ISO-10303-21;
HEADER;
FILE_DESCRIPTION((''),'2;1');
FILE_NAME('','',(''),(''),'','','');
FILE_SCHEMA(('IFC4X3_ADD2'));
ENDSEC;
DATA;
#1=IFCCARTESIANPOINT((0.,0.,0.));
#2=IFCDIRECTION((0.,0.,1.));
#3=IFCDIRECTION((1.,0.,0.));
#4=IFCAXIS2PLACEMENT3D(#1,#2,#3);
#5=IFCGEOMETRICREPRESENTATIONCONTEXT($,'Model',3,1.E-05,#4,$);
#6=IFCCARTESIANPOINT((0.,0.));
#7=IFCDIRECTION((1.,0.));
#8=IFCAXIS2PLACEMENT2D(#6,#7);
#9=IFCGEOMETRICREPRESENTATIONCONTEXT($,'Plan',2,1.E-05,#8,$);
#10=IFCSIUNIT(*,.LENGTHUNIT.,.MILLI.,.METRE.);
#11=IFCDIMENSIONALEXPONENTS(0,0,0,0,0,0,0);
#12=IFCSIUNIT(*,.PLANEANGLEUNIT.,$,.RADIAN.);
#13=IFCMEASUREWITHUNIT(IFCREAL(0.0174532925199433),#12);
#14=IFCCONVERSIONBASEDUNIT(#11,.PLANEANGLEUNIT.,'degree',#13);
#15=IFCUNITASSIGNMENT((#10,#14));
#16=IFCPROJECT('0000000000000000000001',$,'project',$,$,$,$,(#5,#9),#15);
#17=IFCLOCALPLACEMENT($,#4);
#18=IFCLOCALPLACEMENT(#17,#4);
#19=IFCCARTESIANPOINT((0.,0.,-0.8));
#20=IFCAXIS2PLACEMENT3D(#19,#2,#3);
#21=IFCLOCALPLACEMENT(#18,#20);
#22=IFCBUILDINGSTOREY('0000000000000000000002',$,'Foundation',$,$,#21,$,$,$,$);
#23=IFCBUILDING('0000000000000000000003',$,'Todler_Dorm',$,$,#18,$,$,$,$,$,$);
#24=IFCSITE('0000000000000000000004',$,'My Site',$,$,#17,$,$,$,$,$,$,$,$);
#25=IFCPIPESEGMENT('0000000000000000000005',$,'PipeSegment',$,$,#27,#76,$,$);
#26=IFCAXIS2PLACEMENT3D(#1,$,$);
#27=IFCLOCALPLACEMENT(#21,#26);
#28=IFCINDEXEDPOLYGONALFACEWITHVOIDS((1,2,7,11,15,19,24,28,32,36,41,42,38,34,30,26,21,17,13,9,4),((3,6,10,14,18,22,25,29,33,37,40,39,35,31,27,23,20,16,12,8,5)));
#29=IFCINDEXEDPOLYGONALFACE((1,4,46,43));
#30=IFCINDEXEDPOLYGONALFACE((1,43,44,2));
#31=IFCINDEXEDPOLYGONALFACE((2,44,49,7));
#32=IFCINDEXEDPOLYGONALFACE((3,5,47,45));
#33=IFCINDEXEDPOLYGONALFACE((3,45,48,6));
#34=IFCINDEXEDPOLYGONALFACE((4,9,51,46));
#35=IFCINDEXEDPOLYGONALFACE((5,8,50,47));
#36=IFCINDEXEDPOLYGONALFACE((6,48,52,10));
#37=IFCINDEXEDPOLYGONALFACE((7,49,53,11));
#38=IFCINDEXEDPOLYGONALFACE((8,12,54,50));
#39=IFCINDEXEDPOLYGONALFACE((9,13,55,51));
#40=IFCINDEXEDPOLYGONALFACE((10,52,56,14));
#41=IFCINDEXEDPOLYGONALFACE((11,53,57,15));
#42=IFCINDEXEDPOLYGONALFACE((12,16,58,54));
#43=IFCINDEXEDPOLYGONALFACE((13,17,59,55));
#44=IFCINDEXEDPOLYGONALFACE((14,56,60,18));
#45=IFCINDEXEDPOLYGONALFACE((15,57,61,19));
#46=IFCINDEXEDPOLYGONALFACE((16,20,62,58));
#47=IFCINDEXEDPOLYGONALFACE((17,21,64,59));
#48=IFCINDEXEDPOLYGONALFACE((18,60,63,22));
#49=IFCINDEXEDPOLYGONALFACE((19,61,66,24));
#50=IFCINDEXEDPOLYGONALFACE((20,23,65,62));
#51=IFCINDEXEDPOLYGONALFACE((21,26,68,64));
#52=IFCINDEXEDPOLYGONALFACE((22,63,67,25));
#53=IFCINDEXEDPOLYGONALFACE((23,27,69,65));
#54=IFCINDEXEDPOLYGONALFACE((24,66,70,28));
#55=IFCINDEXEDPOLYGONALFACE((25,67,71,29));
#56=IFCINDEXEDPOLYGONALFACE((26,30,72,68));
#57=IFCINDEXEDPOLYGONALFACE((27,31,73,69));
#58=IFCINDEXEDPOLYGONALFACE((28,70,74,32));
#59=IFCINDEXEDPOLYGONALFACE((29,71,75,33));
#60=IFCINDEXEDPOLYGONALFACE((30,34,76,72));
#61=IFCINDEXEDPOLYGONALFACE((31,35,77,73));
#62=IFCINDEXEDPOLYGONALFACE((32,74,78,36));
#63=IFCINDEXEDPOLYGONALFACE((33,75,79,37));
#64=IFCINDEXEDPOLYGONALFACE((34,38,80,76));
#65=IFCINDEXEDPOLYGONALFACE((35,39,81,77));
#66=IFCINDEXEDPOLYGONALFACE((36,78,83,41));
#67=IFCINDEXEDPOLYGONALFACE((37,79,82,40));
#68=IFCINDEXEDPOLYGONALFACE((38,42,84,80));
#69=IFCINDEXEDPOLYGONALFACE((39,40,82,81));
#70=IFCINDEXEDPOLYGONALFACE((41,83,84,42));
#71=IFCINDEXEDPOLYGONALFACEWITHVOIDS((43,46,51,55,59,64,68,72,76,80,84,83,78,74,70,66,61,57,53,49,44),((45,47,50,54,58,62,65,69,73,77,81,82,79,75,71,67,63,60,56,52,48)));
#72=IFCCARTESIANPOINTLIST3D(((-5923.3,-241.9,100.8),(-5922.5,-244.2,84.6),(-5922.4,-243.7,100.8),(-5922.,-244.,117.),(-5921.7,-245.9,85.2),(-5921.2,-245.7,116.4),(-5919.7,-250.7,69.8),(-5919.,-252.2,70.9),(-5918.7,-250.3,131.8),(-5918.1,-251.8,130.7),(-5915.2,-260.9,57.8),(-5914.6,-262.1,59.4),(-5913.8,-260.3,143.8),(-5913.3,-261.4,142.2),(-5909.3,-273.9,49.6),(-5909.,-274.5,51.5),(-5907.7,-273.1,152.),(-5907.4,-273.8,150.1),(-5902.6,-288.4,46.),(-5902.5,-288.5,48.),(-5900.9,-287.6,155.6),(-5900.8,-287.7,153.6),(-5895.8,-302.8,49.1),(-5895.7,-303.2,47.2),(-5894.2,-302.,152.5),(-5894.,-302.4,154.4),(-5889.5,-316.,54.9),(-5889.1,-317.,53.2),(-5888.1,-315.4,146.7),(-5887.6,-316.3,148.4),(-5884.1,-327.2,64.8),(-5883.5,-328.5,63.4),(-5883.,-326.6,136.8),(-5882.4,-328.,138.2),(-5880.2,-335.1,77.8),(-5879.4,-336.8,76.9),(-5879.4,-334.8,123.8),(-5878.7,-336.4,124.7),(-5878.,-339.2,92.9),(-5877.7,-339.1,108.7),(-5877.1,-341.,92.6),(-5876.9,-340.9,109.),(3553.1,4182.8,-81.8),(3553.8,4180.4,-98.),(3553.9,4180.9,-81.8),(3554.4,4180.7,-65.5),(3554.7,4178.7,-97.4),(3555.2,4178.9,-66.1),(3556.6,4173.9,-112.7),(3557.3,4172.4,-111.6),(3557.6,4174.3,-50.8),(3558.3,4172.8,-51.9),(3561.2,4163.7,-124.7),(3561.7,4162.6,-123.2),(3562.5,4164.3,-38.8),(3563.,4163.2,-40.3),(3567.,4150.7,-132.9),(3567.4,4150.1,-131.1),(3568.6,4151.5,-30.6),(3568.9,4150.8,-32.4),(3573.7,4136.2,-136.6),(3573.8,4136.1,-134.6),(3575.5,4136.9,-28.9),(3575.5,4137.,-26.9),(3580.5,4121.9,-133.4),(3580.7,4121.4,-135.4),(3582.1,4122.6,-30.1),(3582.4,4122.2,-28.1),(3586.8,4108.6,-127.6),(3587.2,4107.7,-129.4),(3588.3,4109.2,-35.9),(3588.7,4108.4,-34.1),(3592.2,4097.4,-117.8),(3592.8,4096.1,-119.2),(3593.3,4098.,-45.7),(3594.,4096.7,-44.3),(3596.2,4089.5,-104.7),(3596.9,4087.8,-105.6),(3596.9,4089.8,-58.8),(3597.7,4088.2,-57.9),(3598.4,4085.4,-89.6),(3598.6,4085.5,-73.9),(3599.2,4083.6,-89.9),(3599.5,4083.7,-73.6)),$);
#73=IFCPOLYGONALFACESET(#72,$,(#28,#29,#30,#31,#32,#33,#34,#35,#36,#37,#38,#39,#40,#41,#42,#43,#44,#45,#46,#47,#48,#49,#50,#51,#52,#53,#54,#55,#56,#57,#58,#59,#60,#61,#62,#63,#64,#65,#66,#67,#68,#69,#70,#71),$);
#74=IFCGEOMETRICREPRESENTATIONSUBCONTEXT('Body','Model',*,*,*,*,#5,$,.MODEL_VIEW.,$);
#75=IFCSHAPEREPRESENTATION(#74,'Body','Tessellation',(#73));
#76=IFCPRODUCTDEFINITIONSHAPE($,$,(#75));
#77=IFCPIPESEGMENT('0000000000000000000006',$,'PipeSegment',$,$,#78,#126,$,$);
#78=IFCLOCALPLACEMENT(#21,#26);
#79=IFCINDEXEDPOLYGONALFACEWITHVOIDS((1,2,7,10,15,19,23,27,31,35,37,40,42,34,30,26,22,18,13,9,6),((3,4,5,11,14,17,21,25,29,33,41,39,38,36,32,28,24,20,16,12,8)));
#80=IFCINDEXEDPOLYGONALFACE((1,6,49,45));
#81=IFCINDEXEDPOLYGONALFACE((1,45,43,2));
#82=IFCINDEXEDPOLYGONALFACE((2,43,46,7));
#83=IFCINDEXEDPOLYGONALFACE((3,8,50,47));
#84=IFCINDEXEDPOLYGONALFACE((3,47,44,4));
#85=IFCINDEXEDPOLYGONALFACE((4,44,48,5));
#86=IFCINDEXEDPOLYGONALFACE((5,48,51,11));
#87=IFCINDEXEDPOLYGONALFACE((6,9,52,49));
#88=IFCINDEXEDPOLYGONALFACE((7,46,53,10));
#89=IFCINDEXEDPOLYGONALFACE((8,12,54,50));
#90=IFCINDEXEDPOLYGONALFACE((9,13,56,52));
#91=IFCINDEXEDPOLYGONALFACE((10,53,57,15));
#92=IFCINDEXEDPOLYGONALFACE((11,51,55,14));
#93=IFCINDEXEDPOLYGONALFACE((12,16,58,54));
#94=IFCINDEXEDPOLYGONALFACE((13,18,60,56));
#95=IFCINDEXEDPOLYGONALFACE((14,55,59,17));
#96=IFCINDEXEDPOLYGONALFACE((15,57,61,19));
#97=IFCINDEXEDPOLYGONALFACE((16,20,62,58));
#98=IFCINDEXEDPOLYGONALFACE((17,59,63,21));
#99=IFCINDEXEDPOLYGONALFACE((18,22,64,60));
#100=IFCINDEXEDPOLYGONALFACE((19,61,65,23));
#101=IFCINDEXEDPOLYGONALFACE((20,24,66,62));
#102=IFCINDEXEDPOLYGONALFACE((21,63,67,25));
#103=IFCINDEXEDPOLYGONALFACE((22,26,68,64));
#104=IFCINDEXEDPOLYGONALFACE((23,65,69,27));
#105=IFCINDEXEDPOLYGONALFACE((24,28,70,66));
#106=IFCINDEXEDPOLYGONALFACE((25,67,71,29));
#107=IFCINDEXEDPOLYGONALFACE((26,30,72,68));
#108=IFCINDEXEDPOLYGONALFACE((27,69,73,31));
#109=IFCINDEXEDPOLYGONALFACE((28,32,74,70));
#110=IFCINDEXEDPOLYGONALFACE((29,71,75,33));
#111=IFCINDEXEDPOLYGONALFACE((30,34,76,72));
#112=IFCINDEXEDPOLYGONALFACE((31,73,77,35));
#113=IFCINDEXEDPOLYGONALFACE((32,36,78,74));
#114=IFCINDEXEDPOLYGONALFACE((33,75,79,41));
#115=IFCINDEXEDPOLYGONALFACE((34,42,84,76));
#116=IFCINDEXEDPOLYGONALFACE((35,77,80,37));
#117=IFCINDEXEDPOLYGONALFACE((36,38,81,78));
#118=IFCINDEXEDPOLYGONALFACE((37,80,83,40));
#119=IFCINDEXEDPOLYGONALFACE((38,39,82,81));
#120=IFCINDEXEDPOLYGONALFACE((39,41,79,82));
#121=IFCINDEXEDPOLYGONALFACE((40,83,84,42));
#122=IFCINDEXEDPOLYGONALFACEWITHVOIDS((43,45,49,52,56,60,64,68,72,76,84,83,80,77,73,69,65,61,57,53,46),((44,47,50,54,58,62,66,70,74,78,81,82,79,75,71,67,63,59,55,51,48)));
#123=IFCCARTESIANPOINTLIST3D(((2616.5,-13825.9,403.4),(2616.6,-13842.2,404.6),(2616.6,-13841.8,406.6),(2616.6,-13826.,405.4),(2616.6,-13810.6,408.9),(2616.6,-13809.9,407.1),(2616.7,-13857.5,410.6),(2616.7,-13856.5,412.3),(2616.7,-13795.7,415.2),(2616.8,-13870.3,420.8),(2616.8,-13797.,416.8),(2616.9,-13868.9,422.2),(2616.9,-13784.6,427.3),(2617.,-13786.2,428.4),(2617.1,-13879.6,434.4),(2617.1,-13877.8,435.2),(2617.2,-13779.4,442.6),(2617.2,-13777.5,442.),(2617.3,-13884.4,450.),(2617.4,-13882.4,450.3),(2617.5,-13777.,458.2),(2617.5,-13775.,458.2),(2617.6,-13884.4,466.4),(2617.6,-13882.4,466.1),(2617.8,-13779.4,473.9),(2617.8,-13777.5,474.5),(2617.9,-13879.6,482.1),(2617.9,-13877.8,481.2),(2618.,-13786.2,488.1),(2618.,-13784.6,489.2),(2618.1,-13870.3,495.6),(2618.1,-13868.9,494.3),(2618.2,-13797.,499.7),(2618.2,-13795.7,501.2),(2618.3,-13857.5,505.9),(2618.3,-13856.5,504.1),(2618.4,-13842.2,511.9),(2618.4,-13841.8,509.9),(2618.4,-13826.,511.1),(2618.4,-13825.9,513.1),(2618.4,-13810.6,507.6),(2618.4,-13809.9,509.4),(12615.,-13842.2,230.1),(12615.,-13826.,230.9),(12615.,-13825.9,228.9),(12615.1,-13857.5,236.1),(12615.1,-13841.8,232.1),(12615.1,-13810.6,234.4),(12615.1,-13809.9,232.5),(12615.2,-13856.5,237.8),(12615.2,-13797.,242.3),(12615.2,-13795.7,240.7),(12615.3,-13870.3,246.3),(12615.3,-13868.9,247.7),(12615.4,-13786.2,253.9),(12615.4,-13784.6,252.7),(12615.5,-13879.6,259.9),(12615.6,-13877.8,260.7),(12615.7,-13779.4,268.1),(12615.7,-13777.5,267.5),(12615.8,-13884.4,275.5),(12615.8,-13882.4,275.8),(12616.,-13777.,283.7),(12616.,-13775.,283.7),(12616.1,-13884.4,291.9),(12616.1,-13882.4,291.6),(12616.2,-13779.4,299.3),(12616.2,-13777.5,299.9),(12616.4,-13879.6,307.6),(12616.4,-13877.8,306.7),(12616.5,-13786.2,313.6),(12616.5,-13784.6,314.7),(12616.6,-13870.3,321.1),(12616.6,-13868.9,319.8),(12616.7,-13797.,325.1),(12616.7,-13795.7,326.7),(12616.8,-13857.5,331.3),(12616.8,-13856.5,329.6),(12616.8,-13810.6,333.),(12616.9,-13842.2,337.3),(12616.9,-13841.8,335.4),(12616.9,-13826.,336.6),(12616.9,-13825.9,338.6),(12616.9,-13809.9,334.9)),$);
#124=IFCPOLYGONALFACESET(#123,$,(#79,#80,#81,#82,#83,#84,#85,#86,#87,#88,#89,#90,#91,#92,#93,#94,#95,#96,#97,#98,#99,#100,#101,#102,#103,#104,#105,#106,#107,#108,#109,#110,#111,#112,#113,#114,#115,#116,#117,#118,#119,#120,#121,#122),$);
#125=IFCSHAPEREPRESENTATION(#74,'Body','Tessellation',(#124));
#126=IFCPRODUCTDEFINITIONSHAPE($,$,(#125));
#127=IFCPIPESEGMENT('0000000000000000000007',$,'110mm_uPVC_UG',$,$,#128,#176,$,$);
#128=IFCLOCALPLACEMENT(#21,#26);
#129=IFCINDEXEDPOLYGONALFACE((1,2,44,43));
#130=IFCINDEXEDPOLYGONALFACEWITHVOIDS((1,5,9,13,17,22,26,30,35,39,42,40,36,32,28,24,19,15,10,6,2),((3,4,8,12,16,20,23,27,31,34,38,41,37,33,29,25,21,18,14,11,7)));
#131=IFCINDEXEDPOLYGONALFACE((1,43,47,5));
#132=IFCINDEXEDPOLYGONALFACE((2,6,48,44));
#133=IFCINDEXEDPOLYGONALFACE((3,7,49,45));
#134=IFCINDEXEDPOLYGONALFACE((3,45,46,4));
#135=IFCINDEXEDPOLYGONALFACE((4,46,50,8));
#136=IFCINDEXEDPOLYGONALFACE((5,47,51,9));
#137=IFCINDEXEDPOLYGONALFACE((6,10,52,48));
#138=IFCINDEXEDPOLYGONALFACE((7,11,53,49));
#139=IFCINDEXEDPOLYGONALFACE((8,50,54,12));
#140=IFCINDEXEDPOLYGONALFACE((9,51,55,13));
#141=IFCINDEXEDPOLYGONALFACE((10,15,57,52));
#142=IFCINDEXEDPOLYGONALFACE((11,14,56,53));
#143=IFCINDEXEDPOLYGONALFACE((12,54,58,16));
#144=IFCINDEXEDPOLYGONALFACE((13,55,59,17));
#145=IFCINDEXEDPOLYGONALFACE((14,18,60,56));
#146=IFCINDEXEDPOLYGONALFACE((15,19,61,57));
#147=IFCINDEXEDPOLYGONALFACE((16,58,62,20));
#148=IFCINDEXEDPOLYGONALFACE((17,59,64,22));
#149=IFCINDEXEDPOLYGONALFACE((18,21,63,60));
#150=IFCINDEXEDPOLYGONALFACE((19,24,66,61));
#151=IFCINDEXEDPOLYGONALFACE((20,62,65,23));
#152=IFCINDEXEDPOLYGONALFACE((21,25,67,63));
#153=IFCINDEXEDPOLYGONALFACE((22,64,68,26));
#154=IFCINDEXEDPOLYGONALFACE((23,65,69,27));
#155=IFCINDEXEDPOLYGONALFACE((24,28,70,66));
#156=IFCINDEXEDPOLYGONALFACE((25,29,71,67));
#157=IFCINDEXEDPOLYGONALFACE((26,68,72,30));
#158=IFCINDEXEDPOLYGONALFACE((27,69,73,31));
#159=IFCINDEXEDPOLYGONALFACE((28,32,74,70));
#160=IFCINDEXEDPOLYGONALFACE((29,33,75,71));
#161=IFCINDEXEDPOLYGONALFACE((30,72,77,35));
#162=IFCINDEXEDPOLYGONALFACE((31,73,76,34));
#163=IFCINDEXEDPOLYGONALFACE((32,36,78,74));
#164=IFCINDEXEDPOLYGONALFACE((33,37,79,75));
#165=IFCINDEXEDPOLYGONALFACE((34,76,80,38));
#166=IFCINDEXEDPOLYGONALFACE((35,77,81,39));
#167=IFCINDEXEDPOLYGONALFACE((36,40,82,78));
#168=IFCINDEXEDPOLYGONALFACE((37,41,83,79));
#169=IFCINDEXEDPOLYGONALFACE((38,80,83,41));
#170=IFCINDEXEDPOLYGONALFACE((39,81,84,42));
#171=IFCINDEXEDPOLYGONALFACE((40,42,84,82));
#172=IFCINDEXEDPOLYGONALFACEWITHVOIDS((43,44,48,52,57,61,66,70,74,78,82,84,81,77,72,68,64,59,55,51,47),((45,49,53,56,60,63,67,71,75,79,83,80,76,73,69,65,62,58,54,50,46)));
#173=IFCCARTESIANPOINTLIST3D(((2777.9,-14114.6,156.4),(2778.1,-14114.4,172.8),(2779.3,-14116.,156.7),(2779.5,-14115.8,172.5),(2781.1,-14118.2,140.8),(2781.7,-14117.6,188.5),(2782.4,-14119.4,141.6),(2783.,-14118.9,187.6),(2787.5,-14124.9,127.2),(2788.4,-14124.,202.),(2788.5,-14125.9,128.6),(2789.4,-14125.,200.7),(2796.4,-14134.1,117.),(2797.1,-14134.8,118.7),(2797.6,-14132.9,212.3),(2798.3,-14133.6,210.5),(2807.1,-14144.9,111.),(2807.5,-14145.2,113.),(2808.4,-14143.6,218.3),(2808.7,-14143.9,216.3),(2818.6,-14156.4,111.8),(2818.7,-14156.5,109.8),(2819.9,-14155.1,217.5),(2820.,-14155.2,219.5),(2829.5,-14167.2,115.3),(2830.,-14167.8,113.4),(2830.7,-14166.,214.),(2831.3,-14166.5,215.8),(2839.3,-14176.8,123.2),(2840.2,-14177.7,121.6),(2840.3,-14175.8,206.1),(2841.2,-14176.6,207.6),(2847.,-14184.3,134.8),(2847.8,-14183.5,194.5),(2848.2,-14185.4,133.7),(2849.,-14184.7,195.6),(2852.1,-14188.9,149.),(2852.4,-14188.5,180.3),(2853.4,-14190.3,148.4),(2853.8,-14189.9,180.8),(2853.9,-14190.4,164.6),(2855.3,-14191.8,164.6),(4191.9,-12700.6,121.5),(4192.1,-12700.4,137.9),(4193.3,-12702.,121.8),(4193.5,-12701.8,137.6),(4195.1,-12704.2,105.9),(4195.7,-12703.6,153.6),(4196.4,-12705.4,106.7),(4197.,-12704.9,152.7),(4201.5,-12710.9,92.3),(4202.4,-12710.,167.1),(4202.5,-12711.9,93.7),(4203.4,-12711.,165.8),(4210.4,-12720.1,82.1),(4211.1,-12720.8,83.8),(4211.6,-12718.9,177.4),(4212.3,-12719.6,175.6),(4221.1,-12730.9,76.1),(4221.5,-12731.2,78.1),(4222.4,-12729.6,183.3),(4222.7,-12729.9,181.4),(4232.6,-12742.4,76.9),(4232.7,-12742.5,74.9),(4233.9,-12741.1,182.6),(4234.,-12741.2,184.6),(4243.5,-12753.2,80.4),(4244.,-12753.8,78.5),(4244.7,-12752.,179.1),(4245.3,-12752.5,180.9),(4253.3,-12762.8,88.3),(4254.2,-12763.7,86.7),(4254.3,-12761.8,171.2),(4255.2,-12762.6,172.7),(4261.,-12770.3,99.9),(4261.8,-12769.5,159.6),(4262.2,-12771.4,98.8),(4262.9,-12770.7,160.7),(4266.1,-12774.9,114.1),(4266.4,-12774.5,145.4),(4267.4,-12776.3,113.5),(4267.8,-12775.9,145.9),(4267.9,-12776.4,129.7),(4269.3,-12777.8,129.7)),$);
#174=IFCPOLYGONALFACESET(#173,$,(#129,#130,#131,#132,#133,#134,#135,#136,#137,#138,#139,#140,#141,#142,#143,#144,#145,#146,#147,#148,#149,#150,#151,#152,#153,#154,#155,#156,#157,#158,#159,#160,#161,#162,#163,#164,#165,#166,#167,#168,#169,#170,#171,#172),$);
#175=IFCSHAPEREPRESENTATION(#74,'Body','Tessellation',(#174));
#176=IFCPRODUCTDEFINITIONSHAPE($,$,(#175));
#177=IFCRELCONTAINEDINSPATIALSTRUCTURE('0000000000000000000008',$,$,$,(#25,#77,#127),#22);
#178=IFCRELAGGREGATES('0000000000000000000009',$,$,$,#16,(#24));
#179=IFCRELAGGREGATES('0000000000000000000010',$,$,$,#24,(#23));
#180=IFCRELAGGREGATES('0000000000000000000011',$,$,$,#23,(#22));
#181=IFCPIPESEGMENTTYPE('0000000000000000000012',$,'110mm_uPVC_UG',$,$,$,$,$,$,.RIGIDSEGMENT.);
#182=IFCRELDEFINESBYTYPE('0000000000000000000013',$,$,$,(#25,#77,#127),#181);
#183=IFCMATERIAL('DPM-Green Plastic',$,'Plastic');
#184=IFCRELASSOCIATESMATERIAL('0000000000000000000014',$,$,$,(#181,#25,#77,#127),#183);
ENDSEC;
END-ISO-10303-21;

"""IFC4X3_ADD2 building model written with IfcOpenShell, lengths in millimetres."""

from ifc_helpers import new_model, entity, si_unit, converted_unit, frame, origin_with_axes, origin_2d_with_axis, place, context, subcontext, project, spatial, hollow_circle, extrude, material, material_profile, profile_set, profile_usage, type_object, element, save


model = new_model("IFC4X3_ADD2")

# Units and contexts
model_context = context("Model", 3, precision=1e-05, world=origin_with_axes())
plan_context = context("Plan", 2, precision=1e-05, world=origin_2d_with_axis())
body_context = subcontext(model_context, "Body", "Model", "MODEL_VIEW")
ifc_project = project(units=[si_unit("LENGTHUNIT", "METRE", prefix="MILLI"), converted_unit("PLANEANGLEUNIT", "degree", entity("IfcReal", 0.0174532925199433), si_unit("PLANEANGLEUNIT", "RADIAN"), dimensions=[0, 0, 0, 0, 0, 0, 0])], contexts=[model_context, plan_context])

# Site, building, storey
site_placement = place(None, origin_with_axes())
site = spatial("IfcSite", under=ifc_project, at=site_placement, Name="My Site")
building_placement = place(site_placement, origin_with_axes())
building = spatial("IfcBuilding", under=site, at=building_placement, Name="Todler_Dorm")
storey_placement = place(building_placement, frame((0.0, 0.0, -0.8), z_axis=(0.0, 0.0, 1.0), x_axis=(1.0, 0.0, 0.0)))
storey = spatial("IfcBuildingStorey", under=building, at=storey_placement, Name="Foundation")

# Shared definitions
ifc_material_1 = material(Name="DPM-Green Plastic", Category="Plastic")

# Pipe segments
ifc_material_profile = material_profile(ifc_material_1, hollow_circle(Radius=55.0, WallThickness=2.0))
ifc_profile_set = profile_set([ifc_material_profile])
ifc_profile_usage_1 = profile_usage(ifc_profile_set, cardinal=5)
pipe_segment_type = type_object("IfcPipeSegmentType", Name="110mm_uPVC_UG", PredefinedType="RIGIDSEGMENT", material=ifc_profile_set)
pipe_segment_1_placement = place(storey_placement, frame((-5900.0, -291.7, 100.8), z_axis=(0.90596, 0.423003, -0.017452), x_axis=(-0.423068, 0.906098, 0.0)))
element("IfcPipeSegment", 1, at=pipe_segment_1_placement, inside=storey, type_object=pipe_segment_type, material=ifc_profile_usage_1, Name="PipeSegment", context=body_context, shape_type="SweptSolid", body=[
    extrude(hollow_circle(Radius=55.0, WallThickness=2.0), origin_with_axes(), (0.0, 0.0, 1.0), 10460.0),
])
ifc_profile_usage_2 = profile_usage(ifc_profile_set, cardinal=5)
pipe_segment_2_placement = place(storey_placement, frame((2617.5, -13830.0, 458.2), z_axis=(0.999848, 0.0, -0.017452), x_axis=(0.0, 1.0, 0.0)))
element("IfcPipeSegment", 2, at=pipe_segment_2_placement, inside=storey, type_object=pipe_segment_type, material=ifc_profile_usage_2, Name="PipeSegment", context=body_context, shape_type="SweptSolid", body=[
    extrude(hollow_circle(Radius=55.0, WallThickness=2.0), origin_with_axes(), (0.0, 0.0, 1.0), 10000.0),
])
ifc_profile_usage_3 = profile_usage(ifc_profile_set, cardinal=5)
pipe_segment_3_placement = place(storey_placement, frame((4230.4, -12738.9, 129.7), z_axis=(-0.706999, -0.706999, 0.017452), x_axis=(0.707107, -0.707107, 0.0)))
element("IfcPipeSegment", 3, at=pipe_segment_3_placement, inside=storey, type_object=pipe_segment_type, material=ifc_profile_usage_3, Name="110mm_uPVC_UG", context=body_context, shape_type="SweptSolid", body=[
    extrude(hollow_circle(Radius=55.0, WallThickness=2.0), origin_with_axes(), (0.0, 0.0, 1.0), 2000.0),
])

save(model, "model.ifc")
